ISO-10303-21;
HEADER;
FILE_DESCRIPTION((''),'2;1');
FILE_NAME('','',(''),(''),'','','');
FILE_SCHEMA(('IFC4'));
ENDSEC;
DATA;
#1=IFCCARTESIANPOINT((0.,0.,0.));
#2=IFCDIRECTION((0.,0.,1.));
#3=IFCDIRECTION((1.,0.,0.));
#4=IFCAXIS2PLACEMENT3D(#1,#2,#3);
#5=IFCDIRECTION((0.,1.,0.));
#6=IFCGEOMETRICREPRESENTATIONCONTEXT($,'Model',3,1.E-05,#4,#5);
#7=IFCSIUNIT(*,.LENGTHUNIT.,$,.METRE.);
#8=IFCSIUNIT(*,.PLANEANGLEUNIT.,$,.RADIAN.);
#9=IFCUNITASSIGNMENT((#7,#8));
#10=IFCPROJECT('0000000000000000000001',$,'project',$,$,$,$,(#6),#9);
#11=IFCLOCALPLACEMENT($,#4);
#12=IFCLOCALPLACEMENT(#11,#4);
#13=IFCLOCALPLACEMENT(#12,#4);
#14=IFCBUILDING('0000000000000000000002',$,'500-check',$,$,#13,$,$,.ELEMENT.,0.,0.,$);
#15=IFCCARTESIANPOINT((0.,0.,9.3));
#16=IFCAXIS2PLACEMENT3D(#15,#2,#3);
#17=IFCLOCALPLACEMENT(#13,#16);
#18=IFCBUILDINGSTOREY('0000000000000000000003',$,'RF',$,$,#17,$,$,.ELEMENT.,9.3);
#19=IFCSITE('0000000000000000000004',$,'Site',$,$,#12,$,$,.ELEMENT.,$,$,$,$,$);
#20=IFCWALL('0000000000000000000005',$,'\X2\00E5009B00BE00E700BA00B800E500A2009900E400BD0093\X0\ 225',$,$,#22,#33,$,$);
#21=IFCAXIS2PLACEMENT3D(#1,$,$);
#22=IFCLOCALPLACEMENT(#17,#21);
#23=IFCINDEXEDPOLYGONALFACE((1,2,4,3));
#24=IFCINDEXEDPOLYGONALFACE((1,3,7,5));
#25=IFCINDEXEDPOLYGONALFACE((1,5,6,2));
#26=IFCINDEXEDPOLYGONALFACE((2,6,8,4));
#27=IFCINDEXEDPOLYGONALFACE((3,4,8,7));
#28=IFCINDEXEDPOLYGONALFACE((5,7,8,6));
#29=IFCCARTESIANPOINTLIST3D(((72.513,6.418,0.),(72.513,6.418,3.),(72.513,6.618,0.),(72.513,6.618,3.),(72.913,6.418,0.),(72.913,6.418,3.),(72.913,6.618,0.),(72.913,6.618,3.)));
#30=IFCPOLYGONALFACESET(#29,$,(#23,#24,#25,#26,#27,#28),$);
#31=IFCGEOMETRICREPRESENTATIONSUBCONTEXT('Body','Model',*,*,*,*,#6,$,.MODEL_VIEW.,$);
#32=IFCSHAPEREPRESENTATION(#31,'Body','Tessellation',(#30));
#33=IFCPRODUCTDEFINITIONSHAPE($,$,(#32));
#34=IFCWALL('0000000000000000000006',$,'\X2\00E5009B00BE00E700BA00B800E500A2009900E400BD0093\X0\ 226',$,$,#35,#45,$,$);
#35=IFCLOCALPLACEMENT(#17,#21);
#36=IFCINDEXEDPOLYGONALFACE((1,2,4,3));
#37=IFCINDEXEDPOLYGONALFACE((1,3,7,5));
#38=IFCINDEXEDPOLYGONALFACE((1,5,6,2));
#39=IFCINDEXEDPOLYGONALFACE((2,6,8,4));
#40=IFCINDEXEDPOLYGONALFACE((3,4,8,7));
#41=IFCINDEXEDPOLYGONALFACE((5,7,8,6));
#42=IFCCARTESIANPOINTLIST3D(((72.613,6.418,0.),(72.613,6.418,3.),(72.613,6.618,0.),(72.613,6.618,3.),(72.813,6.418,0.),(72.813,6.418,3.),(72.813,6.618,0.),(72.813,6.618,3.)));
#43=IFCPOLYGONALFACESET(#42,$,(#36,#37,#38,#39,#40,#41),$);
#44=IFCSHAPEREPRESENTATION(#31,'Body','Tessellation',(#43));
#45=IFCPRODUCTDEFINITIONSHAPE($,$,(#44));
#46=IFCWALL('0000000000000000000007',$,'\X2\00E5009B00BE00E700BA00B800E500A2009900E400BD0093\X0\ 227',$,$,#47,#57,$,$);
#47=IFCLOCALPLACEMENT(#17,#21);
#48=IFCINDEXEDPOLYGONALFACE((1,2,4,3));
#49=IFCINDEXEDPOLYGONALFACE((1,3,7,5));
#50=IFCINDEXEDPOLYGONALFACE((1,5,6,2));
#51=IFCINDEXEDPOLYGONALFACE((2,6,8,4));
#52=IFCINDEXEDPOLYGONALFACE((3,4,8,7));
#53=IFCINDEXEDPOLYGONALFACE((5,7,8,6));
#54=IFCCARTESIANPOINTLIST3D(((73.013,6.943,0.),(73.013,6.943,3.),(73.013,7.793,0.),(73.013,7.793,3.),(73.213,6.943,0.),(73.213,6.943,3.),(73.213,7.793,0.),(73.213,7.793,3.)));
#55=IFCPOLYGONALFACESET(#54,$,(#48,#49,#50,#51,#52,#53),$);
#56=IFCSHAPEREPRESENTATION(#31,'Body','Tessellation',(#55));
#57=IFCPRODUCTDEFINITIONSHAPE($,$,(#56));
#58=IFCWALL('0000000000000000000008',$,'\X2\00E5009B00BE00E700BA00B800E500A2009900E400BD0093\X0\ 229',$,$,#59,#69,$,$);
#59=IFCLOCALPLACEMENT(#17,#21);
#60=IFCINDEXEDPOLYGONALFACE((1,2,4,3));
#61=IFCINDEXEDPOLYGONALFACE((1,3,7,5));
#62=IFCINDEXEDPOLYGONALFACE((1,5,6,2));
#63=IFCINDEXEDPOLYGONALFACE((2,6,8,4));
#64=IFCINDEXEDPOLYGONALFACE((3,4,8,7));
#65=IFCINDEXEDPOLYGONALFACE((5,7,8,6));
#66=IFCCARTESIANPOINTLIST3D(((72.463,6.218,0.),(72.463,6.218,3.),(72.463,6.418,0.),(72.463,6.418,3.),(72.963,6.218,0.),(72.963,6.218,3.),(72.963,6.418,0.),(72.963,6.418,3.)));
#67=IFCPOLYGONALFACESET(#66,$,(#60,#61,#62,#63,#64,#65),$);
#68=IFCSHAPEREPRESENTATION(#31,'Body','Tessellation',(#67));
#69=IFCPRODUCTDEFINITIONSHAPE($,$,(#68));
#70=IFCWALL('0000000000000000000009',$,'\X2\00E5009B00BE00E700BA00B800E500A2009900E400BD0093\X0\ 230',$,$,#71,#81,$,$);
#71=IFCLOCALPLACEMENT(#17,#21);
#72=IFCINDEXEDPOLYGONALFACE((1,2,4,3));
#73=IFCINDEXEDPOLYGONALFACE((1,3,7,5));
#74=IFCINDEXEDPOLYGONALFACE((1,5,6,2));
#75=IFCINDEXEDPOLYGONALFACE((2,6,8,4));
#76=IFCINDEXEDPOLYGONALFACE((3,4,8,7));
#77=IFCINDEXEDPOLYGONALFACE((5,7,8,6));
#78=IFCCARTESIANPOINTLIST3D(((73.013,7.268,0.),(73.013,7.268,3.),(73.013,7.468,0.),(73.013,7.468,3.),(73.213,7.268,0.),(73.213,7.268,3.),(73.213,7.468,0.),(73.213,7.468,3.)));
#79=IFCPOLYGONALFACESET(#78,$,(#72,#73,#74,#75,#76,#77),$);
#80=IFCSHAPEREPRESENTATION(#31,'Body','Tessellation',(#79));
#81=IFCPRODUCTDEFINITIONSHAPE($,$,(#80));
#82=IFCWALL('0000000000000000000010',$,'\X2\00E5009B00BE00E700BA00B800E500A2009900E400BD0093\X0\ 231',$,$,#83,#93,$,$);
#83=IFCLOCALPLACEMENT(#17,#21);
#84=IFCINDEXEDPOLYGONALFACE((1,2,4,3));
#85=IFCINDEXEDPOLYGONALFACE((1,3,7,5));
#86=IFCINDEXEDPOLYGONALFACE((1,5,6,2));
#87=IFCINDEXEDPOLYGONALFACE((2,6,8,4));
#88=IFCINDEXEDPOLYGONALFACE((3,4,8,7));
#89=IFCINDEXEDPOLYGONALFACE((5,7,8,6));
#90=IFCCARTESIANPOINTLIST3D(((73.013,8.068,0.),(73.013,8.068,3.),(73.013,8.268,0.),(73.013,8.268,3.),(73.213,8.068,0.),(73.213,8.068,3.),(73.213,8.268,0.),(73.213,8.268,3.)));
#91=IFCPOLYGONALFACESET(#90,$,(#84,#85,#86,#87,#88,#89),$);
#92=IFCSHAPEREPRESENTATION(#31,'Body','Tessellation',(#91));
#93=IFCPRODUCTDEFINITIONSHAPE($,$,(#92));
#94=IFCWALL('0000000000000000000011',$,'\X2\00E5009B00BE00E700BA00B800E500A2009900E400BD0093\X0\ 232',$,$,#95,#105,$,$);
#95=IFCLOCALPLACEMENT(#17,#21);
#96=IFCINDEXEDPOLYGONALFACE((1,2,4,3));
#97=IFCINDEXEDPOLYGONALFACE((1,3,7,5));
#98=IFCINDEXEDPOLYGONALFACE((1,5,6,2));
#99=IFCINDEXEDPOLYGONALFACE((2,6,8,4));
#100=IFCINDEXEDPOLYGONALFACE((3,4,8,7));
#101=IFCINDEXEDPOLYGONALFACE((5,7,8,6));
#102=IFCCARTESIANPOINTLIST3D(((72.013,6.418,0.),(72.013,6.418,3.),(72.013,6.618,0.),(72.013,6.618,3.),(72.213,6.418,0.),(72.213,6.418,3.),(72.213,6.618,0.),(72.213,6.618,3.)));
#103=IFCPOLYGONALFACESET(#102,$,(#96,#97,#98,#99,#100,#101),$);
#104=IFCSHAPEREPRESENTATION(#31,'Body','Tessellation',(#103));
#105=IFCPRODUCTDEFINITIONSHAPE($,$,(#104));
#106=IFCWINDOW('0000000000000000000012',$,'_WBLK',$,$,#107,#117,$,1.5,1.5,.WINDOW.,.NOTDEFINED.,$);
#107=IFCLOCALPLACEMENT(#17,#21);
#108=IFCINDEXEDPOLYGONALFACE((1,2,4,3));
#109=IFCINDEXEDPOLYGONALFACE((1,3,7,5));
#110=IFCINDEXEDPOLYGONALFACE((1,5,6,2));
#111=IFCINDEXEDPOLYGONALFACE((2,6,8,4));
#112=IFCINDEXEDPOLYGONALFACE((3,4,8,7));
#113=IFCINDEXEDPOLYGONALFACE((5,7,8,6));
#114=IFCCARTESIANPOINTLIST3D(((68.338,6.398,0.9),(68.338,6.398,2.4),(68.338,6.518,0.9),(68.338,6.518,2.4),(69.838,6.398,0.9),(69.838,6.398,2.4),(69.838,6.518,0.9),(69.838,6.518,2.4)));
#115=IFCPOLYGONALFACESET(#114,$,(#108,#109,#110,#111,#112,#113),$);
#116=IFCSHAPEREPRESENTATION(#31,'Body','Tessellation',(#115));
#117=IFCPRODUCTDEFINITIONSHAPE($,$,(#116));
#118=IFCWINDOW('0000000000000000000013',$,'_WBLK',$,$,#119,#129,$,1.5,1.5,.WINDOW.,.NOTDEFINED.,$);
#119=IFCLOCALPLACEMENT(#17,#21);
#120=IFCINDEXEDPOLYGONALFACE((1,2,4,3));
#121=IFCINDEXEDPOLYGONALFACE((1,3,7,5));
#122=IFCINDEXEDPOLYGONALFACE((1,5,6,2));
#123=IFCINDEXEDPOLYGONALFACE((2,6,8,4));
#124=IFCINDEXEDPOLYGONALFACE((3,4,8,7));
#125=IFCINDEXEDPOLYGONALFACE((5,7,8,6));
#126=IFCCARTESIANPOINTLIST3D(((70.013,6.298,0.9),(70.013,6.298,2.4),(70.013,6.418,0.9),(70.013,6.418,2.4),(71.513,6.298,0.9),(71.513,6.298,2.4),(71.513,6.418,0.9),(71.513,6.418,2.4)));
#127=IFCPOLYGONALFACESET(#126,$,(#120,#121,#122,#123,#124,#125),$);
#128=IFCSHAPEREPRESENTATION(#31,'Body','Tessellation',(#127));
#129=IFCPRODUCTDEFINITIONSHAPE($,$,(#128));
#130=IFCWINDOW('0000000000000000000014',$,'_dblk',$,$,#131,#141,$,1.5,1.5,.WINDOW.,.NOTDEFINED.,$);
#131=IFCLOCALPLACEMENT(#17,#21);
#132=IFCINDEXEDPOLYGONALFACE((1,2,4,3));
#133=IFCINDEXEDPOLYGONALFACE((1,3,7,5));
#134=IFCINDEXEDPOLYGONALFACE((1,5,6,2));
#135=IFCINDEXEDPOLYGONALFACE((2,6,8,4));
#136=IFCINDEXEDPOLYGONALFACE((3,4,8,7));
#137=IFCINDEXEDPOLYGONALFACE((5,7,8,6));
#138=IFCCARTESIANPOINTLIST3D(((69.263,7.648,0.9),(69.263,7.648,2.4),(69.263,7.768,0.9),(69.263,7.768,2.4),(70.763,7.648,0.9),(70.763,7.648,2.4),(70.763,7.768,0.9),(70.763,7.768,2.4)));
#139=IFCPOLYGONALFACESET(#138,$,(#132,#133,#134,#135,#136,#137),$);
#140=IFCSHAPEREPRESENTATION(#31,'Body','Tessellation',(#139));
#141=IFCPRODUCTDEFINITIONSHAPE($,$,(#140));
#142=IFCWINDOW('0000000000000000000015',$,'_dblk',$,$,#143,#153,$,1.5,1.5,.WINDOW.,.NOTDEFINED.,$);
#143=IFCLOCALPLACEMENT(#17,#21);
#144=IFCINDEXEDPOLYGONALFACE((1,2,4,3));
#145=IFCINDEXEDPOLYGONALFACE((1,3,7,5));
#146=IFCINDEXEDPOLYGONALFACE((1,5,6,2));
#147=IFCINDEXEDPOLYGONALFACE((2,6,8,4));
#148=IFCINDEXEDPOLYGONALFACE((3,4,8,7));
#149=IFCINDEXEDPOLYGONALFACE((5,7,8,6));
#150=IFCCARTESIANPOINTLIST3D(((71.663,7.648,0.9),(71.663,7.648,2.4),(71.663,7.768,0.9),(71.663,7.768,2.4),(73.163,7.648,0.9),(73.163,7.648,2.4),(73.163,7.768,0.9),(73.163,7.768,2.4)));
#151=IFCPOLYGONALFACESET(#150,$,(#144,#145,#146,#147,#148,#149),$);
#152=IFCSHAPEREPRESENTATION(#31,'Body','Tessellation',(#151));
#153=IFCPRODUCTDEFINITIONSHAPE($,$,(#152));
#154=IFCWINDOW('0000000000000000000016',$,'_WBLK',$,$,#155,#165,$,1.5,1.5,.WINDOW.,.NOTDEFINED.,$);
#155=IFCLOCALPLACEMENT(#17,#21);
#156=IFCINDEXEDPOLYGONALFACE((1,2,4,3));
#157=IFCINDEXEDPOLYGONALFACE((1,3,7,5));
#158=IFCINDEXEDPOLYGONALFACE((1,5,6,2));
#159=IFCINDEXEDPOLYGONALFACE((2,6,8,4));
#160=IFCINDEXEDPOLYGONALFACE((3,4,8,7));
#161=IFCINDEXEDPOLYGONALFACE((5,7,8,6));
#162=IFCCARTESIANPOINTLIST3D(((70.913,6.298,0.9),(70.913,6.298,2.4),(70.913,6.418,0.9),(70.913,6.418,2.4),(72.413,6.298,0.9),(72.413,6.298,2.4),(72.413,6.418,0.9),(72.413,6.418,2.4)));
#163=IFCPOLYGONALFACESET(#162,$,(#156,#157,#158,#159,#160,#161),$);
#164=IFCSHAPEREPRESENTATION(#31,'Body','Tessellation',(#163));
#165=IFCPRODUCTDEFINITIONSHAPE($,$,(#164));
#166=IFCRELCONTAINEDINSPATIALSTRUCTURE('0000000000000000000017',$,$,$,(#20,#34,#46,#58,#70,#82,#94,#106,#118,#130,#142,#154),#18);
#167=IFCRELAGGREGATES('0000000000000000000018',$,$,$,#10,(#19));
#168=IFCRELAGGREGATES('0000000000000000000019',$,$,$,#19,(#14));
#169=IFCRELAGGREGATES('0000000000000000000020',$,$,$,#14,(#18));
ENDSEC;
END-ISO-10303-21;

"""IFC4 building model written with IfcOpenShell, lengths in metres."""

from ifc_helpers import new_model, si_unit, direction, frame, frame_2d, origin_with_axes, place, context, subcontext, project, spatial, rectangle, extrude, element, save


model = new_model("IFC4")

# Units and contexts
model_context = context("Model", 3, precision=1e-05, world=origin_with_axes(), true_north=direction((0.0, 1.0, 0.0)))
body_context = subcontext(model_context, "Body", "Model", "MODEL_VIEW")
ifc_project = project(units=[si_unit("LENGTHUNIT", "METRE"), si_unit("PLANEANGLEUNIT", "RADIAN")], contexts=[model_context])

# Site, building, storey
placement = place(None, origin_with_axes())
site_placement = place(placement, origin_with_axes())
site = spatial("IfcSite", under=ifc_project, at=site_placement, Name="Site", CompositionType="ELEMENT")
building_placement = place(site_placement, origin_with_axes())
building = spatial("IfcBuilding", under=site, at=building_placement, Name="500-check", CompositionType="ELEMENT", ElevationOfRefHeight=0.0, ElevationOfTerrain=0.0)
storey_placement = place(building_placement, frame((0.0, 0.0, 9.3), z_axis=(0.0, 0.0, 1.0), x_axis=(1.0, 0.0, 0.0)))
storey = spatial("IfcBuildingStorey", under=building, at=storey_placement, Name="RF", CompositionType="ELEMENT", Elevation=9.3)

# Walls
wall_1_placement = place(storey_placement, frame((72.713, 6.518, 0.0), z_axis=(0.0, 0.0, 1.0), x_axis=(1.0, 0.0, 0.0)))
element("IfcWall", 1, at=wall_1_placement, inside=storey, Name="å\u009b¾çº¸å¢\u0099ä½\u0093 225", context=body_context, shape_type="SweptSolid", body=[
    extrude(rectangle(XDim=0.4, YDim=0.2, at=frame_2d((0.0, 0.0), x_axis=(1.0, 0.0, 0.0))), frame((0.0, 0.0, 0.0), z_axis=(0.0, 0.0, 1.0)), (0.0, 0.0, 1.0), 3.0),
])
wall_2_placement = place(storey_placement, frame((72.713, 6.518, 0.0), z_axis=(0.0, 0.0, 1.0), x_axis=(0.0, -1.0, 0.0)))
element("IfcWall", 2, at=wall_2_placement, inside=storey, Name="å\u009b¾çº¸å¢\u0099ä½\u0093 226", context=body_context, shape_type="SweptSolid", body=[
    extrude(rectangle(XDim=0.2, YDim=0.2, at=frame_2d((0.0, 0.0), x_axis=(1.0, 0.0, 0.0))), frame((0.0, 0.0, 0.0), z_axis=(0.0, 0.0, 1.0)), (0.0, 0.0, 1.0), 3.0),
])
wall_3_placement = place(storey_placement, frame((73.113, 7.368, 0.0), z_axis=(0.0, 0.0, 1.0), x_axis=(0.0, -1.0, 0.0)))
element("IfcWall", 3, at=wall_3_placement, inside=storey, Name="å\u009b¾çº¸å¢\u0099ä½\u0093 227", context=body_context, shape_type="SweptSolid", body=[
    extrude(rectangle(XDim=0.85, YDim=0.2, at=frame_2d((0.0, 0.0), x_axis=(1.0, 0.0, 0.0))), frame((0.0, 0.0, 0.0), z_axis=(0.0, 0.0, 1.0)), (0.0, 0.0, 1.0), 3.0),
])
wall_4_placement = place(storey_placement, frame((72.713, 6.318, 0.0), z_axis=(0.0, 0.0, 1.0), x_axis=(1.0, 0.0, 0.0)))
element("IfcWall", 4, at=wall_4_placement, inside=storey, Name="å\u009b¾çº¸å¢\u0099ä½\u0093 229", context=body_context, shape_type="SweptSolid", body=[
    extrude(rectangle(XDim=0.5, YDim=0.2, at=frame_2d((0.0, 0.0), x_axis=(1.0, 0.0, 0.0))), frame((0.0, 0.0, 0.0), z_axis=(0.0, 0.0, 1.0)), (0.0, 0.0, 1.0), 3.0),
])
for number, where, z_axis, x_axis, name in (
    (5, (73.113, 7.368, 0.0), (0.0, 0.0, 1.0), (1.0, 0.0, 0.0), "å\u009b¾çº¸å¢\u0099ä½\u0093 230"),
    (6, (73.113, 8.168, 0.0), (0.0, 0.0, 1.0), (1.0, 0.0, 0.0), "å\u009b¾çº¸å¢\u0099ä½\u0093 231"),
    (7, (72.113, 6.518, 0.0), (0.0, 0.0, 1.0), (0.0, -1.0, 0.0), "å\u009b¾çº¸å¢\u0099ä½\u0093 232"),
):
    element("IfcWall", number, at=place(storey_placement, frame(where, z_axis=z_axis, x_axis=x_axis)), inside=storey, Name=name, context=body_context, shape_type="SweptSolid", body=[
        extrude(rectangle(XDim=0.2, YDim=0.2, at=frame_2d((0.0, 0.0), x_axis=(1.0, 0.0, 0.0))), frame((0.0, 0.0, 0.0), z_axis=(0.0, 0.0, 1.0)), (0.0, 0.0, 1.0), 3.0),
    ])

# Windows
for number, where, z_axis, x_axis, name in (
    (8, (69.088, 6.458, 0.9), (0.0, 0.0, 1.0), (1.0, 0.0, 0.0), "_WBLK"),
    (9, (70.763, 6.358, 0.9), (0.0, 0.0, 1.0), (1.0, 0.0, 0.0), "_WBLK"),
    (10, (70.013, 7.708, 0.9), (0.0, 0.0, 1.0), (1.0, 0.0, 0.0), "_dblk"),
    (11, (72.413, 7.708, 0.9), (0.0, 0.0, 1.0), (1.0, 0.0, 0.0), "_dblk"),
    (12, (71.663, 6.358, 0.9), (0.0, 0.0, 1.0), (1.0, 0.0, 0.0), "_WBLK"),
):
    element("IfcWindow", number, at=place(storey_placement, frame(where, z_axis=z_axis, x_axis=x_axis)), inside=storey, Name=name, OverallHeight=1.5, OverallWidth=1.5, PartitioningType="NOTDEFINED", PredefinedType="WINDOW", context=body_context, shape_type="SweptSolid", body=[
        extrude(rectangle(XDim=1.5, YDim=0.12, at=frame_2d((0.0, 0.0), x_axis=(1.0, 0.0, 0.0))), frame((0.0, 0.0, 0.0), z_axis=(0.0, 0.0, 1.0)), (0.0, 0.0, 1.0), 1.5),
    ])

save(model, "model.ifc")
